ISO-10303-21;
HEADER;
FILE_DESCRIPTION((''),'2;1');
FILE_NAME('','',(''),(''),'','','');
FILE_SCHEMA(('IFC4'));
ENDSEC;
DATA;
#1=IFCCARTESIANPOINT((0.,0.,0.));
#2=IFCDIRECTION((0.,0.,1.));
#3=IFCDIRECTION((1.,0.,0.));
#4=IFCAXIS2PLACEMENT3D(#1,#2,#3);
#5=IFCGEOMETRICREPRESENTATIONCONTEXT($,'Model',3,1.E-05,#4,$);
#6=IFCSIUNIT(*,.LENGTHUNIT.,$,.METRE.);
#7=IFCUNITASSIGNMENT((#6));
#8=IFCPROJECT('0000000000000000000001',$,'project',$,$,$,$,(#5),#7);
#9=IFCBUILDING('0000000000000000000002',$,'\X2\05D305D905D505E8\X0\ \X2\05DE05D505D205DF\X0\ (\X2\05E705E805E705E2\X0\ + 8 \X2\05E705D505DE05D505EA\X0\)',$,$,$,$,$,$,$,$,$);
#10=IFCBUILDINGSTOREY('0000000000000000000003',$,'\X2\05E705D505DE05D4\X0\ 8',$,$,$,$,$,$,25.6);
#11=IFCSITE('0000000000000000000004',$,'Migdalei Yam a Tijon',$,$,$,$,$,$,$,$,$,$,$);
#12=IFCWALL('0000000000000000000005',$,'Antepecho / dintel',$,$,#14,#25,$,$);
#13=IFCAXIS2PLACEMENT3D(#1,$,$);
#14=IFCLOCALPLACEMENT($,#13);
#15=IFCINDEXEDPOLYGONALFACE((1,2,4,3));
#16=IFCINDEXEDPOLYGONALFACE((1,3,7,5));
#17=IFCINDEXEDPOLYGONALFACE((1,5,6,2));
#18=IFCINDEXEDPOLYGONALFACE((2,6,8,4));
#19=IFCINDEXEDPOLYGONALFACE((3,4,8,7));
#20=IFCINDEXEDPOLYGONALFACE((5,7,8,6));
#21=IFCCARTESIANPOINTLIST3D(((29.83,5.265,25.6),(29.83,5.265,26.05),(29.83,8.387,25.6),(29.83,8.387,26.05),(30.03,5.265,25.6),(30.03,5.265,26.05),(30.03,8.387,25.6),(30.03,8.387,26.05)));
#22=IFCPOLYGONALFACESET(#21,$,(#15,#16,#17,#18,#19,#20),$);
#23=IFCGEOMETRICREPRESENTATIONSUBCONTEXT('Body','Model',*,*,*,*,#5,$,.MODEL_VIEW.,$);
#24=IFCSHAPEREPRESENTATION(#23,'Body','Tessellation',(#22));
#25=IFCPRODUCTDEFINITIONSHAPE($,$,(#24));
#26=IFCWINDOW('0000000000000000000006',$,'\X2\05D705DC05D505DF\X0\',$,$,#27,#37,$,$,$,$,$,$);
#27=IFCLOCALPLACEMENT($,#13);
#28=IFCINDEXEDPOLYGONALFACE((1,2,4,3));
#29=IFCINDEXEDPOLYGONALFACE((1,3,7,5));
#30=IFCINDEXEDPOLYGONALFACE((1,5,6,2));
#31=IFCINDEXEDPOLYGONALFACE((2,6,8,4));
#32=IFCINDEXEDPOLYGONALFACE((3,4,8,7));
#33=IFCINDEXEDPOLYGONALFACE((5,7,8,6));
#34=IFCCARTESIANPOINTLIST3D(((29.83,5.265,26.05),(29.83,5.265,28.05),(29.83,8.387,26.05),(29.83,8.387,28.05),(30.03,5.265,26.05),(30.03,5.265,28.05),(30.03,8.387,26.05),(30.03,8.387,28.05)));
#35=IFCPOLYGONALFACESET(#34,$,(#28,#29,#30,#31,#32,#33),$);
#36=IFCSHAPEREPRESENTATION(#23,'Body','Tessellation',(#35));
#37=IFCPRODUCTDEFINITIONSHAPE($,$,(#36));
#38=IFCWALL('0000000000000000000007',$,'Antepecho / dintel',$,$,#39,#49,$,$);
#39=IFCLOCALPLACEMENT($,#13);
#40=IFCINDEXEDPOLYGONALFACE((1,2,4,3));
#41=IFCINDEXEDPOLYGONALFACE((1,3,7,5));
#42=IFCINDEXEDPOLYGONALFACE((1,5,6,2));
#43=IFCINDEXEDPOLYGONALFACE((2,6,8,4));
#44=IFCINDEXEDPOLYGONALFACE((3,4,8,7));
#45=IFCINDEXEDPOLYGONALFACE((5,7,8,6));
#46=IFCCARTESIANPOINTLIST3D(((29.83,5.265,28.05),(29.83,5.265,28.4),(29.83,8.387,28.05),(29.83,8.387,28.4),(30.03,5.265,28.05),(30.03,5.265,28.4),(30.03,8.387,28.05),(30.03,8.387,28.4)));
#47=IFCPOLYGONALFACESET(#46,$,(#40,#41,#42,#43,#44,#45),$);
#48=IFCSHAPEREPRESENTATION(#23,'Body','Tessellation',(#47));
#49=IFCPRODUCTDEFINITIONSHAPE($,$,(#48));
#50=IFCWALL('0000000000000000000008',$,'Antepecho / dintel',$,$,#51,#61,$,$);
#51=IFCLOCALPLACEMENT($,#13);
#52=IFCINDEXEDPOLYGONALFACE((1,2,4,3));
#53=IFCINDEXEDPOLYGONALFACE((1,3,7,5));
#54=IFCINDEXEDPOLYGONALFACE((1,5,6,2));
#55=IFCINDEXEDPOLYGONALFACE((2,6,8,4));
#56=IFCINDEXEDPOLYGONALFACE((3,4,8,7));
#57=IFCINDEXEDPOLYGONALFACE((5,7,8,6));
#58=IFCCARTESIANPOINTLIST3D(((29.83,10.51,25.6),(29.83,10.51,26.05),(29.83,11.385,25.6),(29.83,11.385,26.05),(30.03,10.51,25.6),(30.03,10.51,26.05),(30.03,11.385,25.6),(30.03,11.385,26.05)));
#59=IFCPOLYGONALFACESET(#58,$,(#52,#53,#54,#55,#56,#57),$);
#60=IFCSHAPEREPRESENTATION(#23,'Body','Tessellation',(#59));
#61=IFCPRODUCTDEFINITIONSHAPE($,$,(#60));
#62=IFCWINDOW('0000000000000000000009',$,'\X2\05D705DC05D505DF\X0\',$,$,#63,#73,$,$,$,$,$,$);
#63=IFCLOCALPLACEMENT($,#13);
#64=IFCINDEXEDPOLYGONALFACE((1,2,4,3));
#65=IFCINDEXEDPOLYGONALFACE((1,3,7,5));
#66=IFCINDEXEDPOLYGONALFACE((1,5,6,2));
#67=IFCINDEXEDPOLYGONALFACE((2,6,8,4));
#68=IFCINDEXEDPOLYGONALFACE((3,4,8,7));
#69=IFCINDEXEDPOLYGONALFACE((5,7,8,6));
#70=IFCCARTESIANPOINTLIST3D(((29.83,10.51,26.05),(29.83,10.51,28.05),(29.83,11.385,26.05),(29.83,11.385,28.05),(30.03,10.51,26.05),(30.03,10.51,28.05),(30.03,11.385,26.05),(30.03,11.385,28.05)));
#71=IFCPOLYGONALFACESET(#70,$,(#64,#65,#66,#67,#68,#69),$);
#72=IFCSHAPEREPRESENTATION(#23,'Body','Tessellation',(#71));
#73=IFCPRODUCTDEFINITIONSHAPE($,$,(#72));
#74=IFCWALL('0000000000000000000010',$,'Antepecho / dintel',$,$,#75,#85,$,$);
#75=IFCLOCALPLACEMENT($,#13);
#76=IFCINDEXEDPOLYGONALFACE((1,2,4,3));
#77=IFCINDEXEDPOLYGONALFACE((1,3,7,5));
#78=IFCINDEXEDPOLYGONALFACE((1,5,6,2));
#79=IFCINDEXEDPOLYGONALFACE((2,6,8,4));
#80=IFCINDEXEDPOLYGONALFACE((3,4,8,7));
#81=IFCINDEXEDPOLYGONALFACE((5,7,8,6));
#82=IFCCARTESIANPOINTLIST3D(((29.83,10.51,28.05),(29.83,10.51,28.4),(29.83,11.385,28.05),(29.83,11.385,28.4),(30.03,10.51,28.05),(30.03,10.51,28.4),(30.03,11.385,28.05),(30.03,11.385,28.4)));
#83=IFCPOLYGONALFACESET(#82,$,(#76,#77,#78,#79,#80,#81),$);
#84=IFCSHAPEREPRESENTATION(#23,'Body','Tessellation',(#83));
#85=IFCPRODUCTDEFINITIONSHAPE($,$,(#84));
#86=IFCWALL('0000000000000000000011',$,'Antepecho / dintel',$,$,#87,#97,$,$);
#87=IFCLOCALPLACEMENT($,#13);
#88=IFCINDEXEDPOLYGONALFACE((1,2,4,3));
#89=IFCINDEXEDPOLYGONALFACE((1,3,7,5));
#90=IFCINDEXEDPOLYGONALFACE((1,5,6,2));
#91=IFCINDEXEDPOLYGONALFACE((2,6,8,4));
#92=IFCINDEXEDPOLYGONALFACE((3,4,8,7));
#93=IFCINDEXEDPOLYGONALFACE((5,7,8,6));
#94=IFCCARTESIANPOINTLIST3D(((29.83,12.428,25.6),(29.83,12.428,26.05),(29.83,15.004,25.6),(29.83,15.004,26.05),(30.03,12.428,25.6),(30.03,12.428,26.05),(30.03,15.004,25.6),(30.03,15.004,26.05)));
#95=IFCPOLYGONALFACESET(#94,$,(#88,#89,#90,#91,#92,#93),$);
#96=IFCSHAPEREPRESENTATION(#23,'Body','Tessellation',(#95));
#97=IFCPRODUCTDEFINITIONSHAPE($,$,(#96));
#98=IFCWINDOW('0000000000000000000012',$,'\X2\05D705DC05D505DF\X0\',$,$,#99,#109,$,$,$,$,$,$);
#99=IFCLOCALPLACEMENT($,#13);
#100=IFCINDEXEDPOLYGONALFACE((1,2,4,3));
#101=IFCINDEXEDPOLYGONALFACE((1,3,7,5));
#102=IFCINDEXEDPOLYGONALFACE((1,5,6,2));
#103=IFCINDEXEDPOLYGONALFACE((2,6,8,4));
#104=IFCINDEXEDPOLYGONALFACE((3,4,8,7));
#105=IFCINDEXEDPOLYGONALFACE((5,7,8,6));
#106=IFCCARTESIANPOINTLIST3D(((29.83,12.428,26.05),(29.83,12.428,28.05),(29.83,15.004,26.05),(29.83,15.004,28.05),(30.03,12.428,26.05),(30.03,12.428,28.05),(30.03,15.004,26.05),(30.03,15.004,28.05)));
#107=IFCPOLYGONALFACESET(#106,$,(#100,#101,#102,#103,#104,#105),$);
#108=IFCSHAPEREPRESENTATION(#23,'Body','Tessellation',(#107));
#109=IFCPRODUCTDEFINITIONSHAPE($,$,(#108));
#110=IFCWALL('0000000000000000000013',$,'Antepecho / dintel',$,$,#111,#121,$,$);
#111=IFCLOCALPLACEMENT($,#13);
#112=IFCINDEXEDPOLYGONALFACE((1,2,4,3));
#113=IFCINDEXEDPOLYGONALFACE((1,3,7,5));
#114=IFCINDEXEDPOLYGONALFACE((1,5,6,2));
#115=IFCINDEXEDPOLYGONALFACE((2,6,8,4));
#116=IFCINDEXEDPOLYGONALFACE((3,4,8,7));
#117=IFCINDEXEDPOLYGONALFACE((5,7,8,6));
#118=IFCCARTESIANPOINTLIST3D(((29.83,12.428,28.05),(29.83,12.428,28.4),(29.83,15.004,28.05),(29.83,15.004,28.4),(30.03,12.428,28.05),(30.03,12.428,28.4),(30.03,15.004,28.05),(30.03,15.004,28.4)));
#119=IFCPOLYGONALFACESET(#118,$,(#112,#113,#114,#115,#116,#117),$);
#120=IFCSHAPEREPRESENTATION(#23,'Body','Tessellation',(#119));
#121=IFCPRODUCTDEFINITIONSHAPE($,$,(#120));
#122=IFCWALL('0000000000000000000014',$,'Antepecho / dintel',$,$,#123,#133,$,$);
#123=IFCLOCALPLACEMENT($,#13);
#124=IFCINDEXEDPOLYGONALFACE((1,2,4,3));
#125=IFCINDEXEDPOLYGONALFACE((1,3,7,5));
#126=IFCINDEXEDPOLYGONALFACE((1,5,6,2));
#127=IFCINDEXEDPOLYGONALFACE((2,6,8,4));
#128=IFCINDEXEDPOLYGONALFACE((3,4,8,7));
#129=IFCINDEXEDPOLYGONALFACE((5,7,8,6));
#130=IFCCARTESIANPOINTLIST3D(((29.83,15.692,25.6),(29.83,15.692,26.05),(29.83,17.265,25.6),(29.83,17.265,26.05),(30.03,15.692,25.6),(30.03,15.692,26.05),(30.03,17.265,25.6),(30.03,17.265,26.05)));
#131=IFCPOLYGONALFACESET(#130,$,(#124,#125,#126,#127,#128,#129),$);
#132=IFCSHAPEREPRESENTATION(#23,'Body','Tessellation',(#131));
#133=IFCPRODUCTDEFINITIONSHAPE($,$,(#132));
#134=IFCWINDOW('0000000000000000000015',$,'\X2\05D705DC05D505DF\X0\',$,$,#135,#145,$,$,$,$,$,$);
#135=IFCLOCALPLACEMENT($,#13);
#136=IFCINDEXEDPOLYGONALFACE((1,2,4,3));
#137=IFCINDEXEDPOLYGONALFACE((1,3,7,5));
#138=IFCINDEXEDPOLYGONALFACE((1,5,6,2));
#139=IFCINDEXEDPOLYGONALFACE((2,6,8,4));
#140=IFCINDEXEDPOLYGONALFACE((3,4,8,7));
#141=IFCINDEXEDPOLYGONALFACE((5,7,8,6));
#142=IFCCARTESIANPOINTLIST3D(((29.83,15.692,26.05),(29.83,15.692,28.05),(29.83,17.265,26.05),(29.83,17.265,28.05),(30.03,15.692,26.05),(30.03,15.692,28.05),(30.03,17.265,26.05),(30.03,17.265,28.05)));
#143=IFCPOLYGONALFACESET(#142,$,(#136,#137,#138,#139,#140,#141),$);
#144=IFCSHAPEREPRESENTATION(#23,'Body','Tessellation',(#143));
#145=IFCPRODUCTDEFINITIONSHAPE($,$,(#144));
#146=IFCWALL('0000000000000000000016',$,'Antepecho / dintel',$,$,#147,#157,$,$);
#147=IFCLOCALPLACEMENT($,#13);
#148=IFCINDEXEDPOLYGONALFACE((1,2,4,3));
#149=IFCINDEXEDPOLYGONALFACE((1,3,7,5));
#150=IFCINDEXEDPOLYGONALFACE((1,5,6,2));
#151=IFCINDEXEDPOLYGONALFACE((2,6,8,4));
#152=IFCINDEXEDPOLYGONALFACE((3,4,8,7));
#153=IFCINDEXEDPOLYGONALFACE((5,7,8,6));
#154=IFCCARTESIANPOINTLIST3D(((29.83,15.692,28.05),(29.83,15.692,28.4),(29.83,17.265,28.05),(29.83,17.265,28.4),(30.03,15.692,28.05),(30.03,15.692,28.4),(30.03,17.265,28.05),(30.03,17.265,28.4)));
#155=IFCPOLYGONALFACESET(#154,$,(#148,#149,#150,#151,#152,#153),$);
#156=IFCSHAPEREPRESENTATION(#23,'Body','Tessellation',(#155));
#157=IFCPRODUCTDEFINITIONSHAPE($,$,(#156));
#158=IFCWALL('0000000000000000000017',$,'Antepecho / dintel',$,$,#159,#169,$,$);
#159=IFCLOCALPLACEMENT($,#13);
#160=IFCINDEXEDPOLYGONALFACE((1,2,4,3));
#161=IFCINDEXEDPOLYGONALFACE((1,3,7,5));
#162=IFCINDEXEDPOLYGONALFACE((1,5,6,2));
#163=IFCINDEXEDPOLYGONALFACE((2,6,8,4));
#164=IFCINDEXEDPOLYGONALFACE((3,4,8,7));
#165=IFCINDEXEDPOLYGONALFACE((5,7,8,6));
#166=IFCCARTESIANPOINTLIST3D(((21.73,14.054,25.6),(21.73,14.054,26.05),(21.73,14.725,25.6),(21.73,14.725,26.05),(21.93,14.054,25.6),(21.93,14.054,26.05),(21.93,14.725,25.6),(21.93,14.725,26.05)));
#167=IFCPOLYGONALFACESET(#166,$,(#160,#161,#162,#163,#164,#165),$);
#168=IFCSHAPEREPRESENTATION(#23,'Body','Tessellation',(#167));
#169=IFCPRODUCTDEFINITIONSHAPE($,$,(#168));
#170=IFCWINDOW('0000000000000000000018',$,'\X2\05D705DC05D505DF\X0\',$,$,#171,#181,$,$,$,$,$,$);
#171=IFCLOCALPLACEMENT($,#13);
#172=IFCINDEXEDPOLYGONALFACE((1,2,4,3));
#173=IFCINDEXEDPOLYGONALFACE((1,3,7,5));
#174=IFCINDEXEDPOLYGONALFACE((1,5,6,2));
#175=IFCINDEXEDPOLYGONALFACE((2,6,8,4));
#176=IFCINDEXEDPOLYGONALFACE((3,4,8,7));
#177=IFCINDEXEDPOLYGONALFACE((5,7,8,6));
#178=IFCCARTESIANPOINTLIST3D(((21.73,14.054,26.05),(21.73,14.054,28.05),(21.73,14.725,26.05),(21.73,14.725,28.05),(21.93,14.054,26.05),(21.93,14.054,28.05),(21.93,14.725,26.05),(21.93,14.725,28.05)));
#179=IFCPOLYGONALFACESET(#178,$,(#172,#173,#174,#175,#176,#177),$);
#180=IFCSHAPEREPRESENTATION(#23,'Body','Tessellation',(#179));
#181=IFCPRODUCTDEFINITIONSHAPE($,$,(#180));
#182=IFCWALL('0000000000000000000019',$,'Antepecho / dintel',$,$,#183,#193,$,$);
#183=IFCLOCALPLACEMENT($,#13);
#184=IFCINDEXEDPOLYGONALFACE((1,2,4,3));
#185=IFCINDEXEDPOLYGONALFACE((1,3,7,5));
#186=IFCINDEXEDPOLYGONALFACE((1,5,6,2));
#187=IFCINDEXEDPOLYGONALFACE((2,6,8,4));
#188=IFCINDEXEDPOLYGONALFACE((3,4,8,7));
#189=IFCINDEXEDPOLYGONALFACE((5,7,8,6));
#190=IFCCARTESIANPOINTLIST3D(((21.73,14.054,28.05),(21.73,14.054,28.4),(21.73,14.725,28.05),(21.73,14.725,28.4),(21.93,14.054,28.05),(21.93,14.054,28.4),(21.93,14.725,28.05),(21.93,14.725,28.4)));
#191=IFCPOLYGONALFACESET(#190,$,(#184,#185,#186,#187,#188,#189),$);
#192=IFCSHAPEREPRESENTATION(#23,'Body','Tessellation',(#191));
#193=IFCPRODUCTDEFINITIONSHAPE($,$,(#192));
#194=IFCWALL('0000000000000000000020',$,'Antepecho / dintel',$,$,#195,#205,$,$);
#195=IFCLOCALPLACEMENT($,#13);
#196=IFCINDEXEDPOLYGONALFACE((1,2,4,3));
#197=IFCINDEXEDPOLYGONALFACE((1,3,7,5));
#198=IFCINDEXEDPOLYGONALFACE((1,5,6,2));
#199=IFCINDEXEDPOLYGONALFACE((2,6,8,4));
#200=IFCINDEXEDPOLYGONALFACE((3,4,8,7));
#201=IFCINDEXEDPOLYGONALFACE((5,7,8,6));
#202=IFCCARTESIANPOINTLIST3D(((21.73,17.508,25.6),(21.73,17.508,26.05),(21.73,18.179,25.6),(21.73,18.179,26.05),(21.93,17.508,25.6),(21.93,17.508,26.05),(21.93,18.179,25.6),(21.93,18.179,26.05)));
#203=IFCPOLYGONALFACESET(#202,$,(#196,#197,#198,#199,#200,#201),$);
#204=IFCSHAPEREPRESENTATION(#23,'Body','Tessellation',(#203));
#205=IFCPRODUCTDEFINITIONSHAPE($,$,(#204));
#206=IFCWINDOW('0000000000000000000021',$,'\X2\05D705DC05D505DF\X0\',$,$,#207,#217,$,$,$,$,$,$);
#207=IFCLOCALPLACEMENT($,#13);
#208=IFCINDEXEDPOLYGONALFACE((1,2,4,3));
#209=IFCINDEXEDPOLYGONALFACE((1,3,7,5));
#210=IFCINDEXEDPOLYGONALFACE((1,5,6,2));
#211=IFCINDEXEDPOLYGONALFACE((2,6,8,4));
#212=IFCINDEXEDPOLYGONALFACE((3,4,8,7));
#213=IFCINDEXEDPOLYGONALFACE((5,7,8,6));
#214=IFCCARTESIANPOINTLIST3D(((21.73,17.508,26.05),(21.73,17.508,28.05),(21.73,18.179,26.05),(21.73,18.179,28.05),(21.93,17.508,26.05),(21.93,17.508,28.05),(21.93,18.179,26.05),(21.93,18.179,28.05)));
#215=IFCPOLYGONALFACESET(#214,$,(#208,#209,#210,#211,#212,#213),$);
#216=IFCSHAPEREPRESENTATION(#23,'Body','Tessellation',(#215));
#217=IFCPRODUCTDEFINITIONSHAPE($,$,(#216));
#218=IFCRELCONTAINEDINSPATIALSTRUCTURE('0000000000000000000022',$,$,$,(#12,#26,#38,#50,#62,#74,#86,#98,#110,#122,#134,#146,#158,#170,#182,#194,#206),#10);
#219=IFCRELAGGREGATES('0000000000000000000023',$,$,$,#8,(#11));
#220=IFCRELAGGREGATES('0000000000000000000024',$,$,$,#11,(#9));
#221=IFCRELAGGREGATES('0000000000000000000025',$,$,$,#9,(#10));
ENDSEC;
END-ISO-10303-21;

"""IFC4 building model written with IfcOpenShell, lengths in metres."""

from ifc_helpers import new_model, si_unit, frame, origin_with_axes, context, subcontext, project, spatial, line, indexed_curve, outline, extrude, element, save


model = new_model("IFC4")

# Units and contexts
model_context = context("Model", 3, precision=1e-05, world=origin_with_axes())
body_context = subcontext(model_context, "Body", "Model", "MODEL_VIEW")
ifc_project = project(units=[si_unit("LENGTHUNIT", "METRE")], contexts=[model_context])

# Site, building, storey
site = spatial("IfcSite", under=ifc_project, Name="Migdalei Yam a Tijon")
building = spatial("IfcBuilding", under=site, Name="דיור מוגן (קרקע + 8 קומות)")
storey = spatial("IfcBuildingStorey", under=building, Name="קומה 8", Elevation=25.6)

# Wall
element("IfcWall", 1, inside=storey, Name="Antepecho / dintel", context=body_context, shape_type="SweptSolid", body=[
    extrude(outline(indexed_curve([(0.0, 0.0), (0.2, 0.0), (0.2, 3.122), (0.0, 3.122)], segments=[line(1, 2, 3, 4, 1)])), frame((29.83, 5.265, 25.6), z_axis=(0.0, 0.0, 1.0), x_axis=(1.0, 0.0, 0.0)), (0.0, 0.0, 1.0), 0.45),
])

# Window
element("IfcWindow", 2, inside=storey, Name="חלון", context=body_context, shape_type="SweptSolid", body=[
    extrude(outline(indexed_curve([(0.0, 0.0), (0.2, 0.0), (0.2, 3.122), (0.0, 3.122)], segments=[line(1, 2, 3, 4, 1)])), frame((29.83, 5.265, 26.05), z_axis=(0.0, 0.0, 1.0), x_axis=(1.0, 0.0, 0.0)), (0.0, 0.0, 1.0), 2.0),
])

# Walls
element("IfcWall", 3, inside=storey, Name="Antepecho / dintel", context=body_context, shape_type="SweptSolid", body=[
    extrude(outline(indexed_curve([(0.0, 0.0), (0.2, 0.0), (0.2, 3.122), (0.0, 3.122)], segments=[line(1, 2, 3, 4, 1)])), frame((29.83, 5.265, 28.05), z_axis=(0.0, 0.0, 1.0), x_axis=(1.0, 0.0, 0.0)), (0.0, 0.0, 1.0), 0.35),
])
element("IfcWall", 4, inside=storey, Name="Antepecho / dintel", context=body_context, shape_type="SweptSolid", body=[
    extrude(outline(indexed_curve([(0.0, 0.0), (0.2, 0.0), (0.2, 0.875), (0.0, 0.875)], segments=[line(1, 2, 3, 4, 1)])), frame((29.83, 10.51, 25.6), z_axis=(0.0, 0.0, 1.0), x_axis=(1.0, 0.0, 0.0)), (0.0, 0.0, 1.0), 0.45),
])

# Window
element("IfcWindow", 5, inside=storey, Name="חלון", context=body_context, shape_type="SweptSolid", body=[
    extrude(outline(indexed_curve([(0.0, 0.0), (0.2, 0.0), (0.2, 0.875), (0.0, 0.875)], segments=[line(1, 2, 3, 4, 1)])), frame((29.83, 10.51, 26.05), z_axis=(0.0, 0.0, 1.0), x_axis=(1.0, 0.0, 0.0)), (0.0, 0.0, 1.0), 2.0),
])

# Walls
element("IfcWall", 6, inside=storey, Name="Antepecho / dintel", context=body_context, shape_type="SweptSolid", body=[
    extrude(outline(indexed_curve([(0.0, 0.0), (0.2, 0.0), (0.2, 0.875), (0.0, 0.875)], segments=[line(1, 2, 3, 4, 1)])), frame((29.83, 10.51, 28.05), z_axis=(0.0, 0.0, 1.0), x_axis=(1.0, 0.0, 0.0)), (0.0, 0.0, 1.0), 0.35),
])
element("IfcWall", 7, inside=storey, Name="Antepecho / dintel", context=body_context, shape_type="SweptSolid", body=[
    extrude(outline(indexed_curve([(0.0, 0.0), (0.2, 0.0), (0.2, 2.576), (0.0, 2.576)], segments=[line(1, 2, 3, 4, 1)])), frame((29.83, 12.428, 25.6), z_axis=(0.0, 0.0, 1.0), x_axis=(1.0, 0.0, 0.0)), (0.0, 0.0, 1.0), 0.45),
])

# Window
element("IfcWindow", 8, inside=storey, Name="חלון", context=body_context, shape_type="SweptSolid", body=[
    extrude(outline(indexed_curve([(0.0, 0.0), (0.2, 0.0), (0.2, 2.576), (0.0, 2.576)], segments=[line(1, 2, 3, 4, 1)])), frame((29.83, 12.428, 26.05), z_axis=(0.0, 0.0, 1.0), x_axis=(1.0, 0.0, 0.0)), (0.0, 0.0, 1.0), 2.0),
])

# Walls
element("IfcWall", 9, inside=storey, Name="Antepecho / dintel", context=body_context, shape_type="SweptSolid", body=[
    extrude(outline(indexed_curve([(0.0, 0.0), (0.2, 0.0), (0.2, 2.576), (0.0, 2.576)], segments=[line(1, 2, 3, 4, 1)])), frame((29.83, 12.428, 28.05), z_axis=(0.0, 0.0, 1.0), x_axis=(1.0, 0.0, 0.0)), (0.0, 0.0, 1.0), 0.35),
])
element("IfcWall", 10, inside=storey, Name="Antepecho / dintel", context=body_context, shape_type="SweptSolid", body=[
    extrude(outline(indexed_curve([(0.0, 0.0), (0.2, 0.0), (0.2, 1.573), (0.0, 1.573)], segments=[line(1, 2, 3, 4, 1)])), frame((29.83, 15.692, 25.6), z_axis=(0.0, 0.0, 1.0), x_axis=(1.0, 0.0, 0.0)), (0.0, 0.0, 1.0), 0.45),
])

# Window
element("IfcWindow", 11, inside=storey, Name="חלון", context=body_context, shape_type="SweptSolid", body=[
    extrude(outline(indexed_curve([(0.0, 0.0), (0.2, 0.0), (0.2, 1.573), (0.0, 1.573)], segments=[line(1, 2, 3, 4, 1)])), frame((29.83, 15.692, 26.05), z_axis=(0.0, 0.0, 1.0), x_axis=(1.0, 0.0, 0.0)), (0.0, 0.0, 1.0), 2.0),
])

# Walls
element("IfcWall", 12, inside=storey, Name="Antepecho / dintel", context=body_context, shape_type="SweptSolid", body=[
    extrude(outline(indexed_curve([(0.0, 0.0), (0.2, 0.0), (0.2, 1.573), (0.0, 1.573)], segments=[line(1, 2, 3, 4, 1)])), frame((29.83, 15.692, 28.05), z_axis=(0.0, 0.0, 1.0), x_axis=(1.0, 0.0, 0.0)), (0.0, 0.0, 1.0), 0.35),
])
element("IfcWall", 13, inside=storey, Name="Antepecho / dintel", context=body_context, shape_type="SweptSolid", body=[
    extrude(outline(indexed_curve([(0.0, 0.0), (0.2, 0.0), (0.2, 0.671), (0.0, 0.671)], segments=[line(1, 2, 3, 4, 1)])), frame((21.73, 14.054, 25.6), z_axis=(0.0, 0.0, 1.0), x_axis=(1.0, 0.0, 0.0)), (0.0, 0.0, 1.0), 0.45),
])

# Window
element("IfcWindow", 14, inside=storey, Name="חלון", context=body_context, shape_type="SweptSolid", body=[
    extrude(outline(indexed_curve([(0.0, 0.0), (0.2, 0.0), (0.2, 0.671), (0.0, 0.671)], segments=[line(1, 2, 3, 4, 1)])), frame((21.73, 14.054, 26.05), z_axis=(0.0, 0.0, 1.0), x_axis=(1.0, 0.0, 0.0)), (0.0, 0.0, 1.0), 2.0),
])

# Walls
element("IfcWall", 15, inside=storey, Name="Antepecho / dintel", context=body_context, shape_type="SweptSolid", body=[
    extrude(outline(indexed_curve([(0.0, 0.0), (0.2, 0.0), (0.2, 0.671), (0.0, 0.671)], segments=[line(1, 2, 3, 4, 1)])), frame((21.73, 14.054, 28.05), z_axis=(0.0, 0.0, 1.0), x_axis=(1.0, 0.0, 0.0)), (0.0, 0.0, 1.0), 0.35),
])
element("IfcWall", 16, inside=storey, Name="Antepecho / dintel", context=body_context, shape_type="SweptSolid", body=[
    extrude(outline(indexed_curve([(0.0, 0.0), (0.2, 0.0), (0.2, 0.671), (0.0, 0.671)], segments=[line(1, 2, 3, 4, 1)])), frame((21.73, 17.508, 25.6), z_axis=(0.0, 0.0, 1.0), x_axis=(1.0, 0.0, 0.0)), (0.0, 0.0, 1.0), 0.45),
])

# Window
element("IfcWindow", 17, inside=storey, Name="חלון", context=body_context, shape_type="SweptSolid", body=[
    extrude(outline(indexed_curve([(0.0, 0.0), (0.2, 0.0), (0.2, 0.671), (0.0, 0.671)], segments=[line(1, 2, 3, 4, 1)])), frame((21.73, 17.508, 26.05), z_axis=(0.0, 0.0, 1.0), x_axis=(1.0, 0.0, 0.0)), (0.0, 0.0, 1.0), 2.0),
])

save(model, "model.ifc")
